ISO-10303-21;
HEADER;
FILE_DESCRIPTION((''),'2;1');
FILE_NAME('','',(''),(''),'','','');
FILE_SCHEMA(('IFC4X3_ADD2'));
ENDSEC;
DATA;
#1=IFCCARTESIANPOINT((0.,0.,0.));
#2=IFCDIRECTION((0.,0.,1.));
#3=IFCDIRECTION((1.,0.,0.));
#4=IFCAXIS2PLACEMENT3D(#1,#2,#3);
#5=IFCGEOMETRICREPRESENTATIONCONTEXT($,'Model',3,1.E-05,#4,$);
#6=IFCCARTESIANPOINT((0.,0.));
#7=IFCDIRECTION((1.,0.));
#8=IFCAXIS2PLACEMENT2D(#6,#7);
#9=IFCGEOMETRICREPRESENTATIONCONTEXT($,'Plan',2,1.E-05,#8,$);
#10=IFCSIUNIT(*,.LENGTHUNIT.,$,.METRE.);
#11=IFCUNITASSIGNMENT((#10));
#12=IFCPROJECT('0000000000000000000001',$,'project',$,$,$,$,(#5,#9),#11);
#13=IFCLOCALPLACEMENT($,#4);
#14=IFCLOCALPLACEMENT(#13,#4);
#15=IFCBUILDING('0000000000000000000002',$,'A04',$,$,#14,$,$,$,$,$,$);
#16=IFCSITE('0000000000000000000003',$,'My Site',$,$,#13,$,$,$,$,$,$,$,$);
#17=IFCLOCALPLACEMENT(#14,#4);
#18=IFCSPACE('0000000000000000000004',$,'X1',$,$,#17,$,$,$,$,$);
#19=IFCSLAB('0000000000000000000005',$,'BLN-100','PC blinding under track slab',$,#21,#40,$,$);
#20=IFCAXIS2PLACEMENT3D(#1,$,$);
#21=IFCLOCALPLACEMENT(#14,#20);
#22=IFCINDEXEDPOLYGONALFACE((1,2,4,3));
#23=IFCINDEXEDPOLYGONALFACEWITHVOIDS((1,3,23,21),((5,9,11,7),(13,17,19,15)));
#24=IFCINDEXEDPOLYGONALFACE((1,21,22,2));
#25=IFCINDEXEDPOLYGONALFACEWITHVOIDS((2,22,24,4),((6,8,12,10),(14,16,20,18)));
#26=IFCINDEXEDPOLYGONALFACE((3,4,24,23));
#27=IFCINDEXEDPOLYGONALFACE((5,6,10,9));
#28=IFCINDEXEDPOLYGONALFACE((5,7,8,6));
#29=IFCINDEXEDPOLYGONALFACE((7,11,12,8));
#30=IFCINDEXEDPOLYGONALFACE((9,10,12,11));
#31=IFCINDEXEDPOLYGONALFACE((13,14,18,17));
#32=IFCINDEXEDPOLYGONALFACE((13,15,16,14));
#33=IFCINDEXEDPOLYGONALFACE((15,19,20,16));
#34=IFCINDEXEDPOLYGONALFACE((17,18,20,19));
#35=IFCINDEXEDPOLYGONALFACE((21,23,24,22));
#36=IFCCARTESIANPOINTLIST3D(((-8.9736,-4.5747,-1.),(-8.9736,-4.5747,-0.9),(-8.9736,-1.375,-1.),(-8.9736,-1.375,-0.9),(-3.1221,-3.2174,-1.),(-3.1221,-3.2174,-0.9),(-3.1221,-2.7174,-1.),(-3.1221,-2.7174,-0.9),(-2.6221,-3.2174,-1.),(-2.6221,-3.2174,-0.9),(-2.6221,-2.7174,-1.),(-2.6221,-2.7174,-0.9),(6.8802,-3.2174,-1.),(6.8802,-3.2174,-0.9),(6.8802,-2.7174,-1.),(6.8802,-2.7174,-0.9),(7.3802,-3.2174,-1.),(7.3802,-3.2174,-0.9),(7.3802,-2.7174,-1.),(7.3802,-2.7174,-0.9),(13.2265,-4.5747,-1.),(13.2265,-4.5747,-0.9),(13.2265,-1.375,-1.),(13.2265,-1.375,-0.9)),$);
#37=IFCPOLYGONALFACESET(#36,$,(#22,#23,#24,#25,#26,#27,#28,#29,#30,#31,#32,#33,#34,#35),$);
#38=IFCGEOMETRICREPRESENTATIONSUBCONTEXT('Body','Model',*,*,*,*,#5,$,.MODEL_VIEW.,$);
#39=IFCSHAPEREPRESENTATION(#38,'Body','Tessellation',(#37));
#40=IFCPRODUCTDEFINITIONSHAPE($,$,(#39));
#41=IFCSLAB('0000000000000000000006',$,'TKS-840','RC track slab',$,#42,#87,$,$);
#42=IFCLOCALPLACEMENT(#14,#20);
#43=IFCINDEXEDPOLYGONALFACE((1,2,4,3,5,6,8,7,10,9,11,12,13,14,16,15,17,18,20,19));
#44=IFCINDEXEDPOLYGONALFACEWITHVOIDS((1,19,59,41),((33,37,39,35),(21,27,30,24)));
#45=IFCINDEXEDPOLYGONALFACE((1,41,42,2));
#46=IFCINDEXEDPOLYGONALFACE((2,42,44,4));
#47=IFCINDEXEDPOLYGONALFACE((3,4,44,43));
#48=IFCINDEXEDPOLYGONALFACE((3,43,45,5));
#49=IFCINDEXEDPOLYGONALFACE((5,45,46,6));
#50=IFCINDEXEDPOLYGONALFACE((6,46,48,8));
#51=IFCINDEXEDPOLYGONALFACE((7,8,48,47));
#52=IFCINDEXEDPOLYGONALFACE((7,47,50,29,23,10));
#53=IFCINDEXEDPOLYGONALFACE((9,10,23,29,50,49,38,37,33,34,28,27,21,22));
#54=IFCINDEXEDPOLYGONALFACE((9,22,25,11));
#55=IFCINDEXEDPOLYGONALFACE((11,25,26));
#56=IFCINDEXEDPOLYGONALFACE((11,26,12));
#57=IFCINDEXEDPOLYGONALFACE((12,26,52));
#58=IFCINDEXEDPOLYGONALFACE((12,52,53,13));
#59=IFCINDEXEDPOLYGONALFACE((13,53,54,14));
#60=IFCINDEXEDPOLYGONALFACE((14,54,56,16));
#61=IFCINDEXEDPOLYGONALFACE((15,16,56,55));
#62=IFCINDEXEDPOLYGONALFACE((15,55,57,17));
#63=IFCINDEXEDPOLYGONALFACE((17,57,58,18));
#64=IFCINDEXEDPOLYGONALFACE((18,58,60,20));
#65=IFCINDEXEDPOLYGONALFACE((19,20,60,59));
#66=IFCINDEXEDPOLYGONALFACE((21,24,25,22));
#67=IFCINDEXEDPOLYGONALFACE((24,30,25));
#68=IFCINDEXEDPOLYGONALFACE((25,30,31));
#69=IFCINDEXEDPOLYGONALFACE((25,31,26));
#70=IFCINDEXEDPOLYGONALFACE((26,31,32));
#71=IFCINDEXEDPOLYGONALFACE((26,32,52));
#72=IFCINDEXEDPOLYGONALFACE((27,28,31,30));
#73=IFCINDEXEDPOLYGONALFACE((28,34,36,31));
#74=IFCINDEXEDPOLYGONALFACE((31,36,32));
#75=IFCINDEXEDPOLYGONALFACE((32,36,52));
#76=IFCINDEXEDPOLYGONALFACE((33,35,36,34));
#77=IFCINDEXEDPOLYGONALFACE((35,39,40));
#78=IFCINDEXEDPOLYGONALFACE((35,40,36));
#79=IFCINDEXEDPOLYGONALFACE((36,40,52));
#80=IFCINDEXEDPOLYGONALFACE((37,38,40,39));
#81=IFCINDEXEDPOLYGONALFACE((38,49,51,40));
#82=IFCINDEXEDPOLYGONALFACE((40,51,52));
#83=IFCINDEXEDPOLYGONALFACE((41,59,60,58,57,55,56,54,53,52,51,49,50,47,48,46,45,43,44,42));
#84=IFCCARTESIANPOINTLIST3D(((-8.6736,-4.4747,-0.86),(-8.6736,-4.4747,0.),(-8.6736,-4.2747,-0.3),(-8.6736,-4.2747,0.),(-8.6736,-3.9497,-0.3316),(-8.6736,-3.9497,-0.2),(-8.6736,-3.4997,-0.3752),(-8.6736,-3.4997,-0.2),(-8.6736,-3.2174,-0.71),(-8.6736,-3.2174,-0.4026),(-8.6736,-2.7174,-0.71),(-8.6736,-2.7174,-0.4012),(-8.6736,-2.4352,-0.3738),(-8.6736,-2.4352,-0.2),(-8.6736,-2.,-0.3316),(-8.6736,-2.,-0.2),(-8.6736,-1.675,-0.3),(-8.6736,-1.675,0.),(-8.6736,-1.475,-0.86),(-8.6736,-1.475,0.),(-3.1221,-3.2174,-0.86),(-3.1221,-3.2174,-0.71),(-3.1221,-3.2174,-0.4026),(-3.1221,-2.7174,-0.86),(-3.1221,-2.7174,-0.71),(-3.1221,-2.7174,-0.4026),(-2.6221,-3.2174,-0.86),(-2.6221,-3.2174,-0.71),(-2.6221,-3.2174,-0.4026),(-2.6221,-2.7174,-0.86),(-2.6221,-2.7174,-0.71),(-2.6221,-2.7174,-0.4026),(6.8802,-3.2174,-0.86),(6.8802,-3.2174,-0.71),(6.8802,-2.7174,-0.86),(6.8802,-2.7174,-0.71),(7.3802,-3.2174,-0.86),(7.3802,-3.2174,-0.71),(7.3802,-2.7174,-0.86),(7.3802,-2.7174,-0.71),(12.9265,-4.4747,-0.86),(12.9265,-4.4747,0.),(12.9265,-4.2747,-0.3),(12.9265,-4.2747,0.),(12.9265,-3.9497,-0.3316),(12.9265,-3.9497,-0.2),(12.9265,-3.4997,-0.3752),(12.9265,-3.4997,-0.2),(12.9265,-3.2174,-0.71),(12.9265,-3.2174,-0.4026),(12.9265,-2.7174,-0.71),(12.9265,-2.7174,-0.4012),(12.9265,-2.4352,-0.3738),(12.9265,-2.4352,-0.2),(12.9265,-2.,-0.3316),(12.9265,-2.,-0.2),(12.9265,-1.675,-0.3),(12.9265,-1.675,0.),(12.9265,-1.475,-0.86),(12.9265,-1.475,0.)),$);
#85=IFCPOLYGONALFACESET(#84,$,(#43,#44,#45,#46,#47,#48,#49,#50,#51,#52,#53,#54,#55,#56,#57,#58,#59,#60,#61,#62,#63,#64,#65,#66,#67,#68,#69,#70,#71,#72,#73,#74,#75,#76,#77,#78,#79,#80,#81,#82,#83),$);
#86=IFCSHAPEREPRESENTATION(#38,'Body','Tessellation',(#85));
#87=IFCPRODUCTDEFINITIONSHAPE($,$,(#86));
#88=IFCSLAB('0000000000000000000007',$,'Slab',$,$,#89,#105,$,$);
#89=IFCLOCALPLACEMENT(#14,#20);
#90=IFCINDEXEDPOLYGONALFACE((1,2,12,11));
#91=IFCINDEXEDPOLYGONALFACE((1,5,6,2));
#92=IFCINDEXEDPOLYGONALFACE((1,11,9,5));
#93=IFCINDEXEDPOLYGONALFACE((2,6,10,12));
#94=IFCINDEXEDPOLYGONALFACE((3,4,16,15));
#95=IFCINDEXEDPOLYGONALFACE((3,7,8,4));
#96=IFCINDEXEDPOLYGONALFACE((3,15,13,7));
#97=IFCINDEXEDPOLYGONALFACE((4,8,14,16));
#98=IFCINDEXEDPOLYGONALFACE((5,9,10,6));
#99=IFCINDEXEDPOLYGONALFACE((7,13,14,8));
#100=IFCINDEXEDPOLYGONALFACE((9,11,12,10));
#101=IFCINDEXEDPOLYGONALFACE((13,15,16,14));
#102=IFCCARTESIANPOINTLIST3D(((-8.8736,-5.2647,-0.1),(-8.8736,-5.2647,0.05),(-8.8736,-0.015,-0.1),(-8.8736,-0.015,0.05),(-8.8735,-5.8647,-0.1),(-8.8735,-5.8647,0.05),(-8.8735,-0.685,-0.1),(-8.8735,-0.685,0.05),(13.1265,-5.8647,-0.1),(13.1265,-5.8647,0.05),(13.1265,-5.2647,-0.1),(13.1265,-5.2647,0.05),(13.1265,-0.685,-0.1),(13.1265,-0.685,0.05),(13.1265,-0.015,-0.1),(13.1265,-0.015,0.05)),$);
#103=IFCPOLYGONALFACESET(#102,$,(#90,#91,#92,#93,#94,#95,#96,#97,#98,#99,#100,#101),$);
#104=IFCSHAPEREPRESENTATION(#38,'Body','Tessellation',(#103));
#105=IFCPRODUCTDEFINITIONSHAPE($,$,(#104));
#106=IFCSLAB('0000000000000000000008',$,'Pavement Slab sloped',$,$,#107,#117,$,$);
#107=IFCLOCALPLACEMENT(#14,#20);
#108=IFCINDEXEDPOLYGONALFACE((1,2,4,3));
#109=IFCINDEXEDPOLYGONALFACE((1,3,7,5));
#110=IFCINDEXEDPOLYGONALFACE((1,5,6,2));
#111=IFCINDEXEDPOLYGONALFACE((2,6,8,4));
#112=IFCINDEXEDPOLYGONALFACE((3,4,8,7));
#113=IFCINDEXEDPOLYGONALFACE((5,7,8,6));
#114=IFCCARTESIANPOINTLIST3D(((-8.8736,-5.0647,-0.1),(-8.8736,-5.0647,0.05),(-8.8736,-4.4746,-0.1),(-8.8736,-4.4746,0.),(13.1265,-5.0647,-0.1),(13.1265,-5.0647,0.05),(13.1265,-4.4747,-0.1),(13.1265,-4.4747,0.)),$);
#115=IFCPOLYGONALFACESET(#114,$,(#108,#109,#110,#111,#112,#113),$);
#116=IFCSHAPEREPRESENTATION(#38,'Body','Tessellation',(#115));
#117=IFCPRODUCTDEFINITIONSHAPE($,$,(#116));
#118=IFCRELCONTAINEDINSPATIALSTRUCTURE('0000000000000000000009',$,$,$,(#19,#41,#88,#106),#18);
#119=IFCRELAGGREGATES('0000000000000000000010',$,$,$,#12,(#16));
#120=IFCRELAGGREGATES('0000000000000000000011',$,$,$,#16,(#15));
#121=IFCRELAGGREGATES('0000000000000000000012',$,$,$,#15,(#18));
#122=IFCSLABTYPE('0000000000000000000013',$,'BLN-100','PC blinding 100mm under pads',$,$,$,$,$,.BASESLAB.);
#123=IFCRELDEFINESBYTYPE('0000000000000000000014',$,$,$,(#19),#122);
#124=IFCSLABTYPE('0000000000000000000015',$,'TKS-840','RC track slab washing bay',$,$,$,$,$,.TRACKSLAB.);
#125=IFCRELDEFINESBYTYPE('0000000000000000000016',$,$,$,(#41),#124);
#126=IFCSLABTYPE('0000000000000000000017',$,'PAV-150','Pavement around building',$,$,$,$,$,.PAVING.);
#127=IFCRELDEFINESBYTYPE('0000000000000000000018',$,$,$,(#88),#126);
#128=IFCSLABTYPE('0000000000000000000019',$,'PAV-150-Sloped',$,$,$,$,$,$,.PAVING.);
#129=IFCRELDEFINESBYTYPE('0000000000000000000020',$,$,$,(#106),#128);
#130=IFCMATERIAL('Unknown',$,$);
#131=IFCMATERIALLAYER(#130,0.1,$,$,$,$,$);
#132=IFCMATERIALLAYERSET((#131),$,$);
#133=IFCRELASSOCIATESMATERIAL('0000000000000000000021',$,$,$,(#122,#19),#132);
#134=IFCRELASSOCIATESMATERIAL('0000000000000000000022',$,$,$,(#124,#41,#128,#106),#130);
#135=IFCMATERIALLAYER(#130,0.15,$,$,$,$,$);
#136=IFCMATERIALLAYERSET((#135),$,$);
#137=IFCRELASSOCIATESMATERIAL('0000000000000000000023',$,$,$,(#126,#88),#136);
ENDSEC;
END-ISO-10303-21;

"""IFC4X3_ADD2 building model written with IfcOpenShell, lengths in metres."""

from ifc_helpers import new_model, si_unit, frame, origin_with_axes, origin_2d_with_axis, place, context, subcontext, project, spatial, line, indexed_curve, outline, composite_profile, extrude, material, layer, layer_set, layer_usage, material_profile, profile_set, profile_usage, type_object, element, save


model = new_model("IFC4X3_ADD2")

# Units and contexts
model_context = context("Model", 3, precision=1e-05, world=origin_with_axes())
plan_context = context("Plan", 2, precision=1e-05, world=origin_2d_with_axis())
body_context = subcontext(model_context, "Body", "Model", "MODEL_VIEW")
ifc_project = project(units=[si_unit("LENGTHUNIT", "METRE")], contexts=[model_context, plan_context])

# Site, building, space
site_placement = place(None, origin_with_axes())
site = spatial("IfcSite", under=ifc_project, at=site_placement, Name="My Site")
building_placement = place(site_placement, origin_with_axes())
building = spatial("IfcBuilding", under=site, at=building_placement, Name="A04")
space_placement = place(building_placement, origin_with_axes())
space = spatial("IfcSpace", under=building, at=space_placement, Name="X1")

# Slab
ifc_material_1 = material(Name="Unknown")
ifc_layer_1 = layer(ifc_material_1, 0.1)
ifc_layer_set_1 = layer_set([ifc_layer_1])
ifc_layer_usage_1 = layer_usage(ifc_layer_set_1, "AXIS3", "POSITIVE", -0.1)
slab_type_1 = type_object("IfcSlabType", Name="BLN-100", Description="PC blinding 100mm under pads", PredefinedType="BASESLAB", material=ifc_layer_set_1)
slab_1_placement = place(space_placement, frame((-8.9736, -1.375, -0.9), z_axis=(0.0, 0.0, 1.0), x_axis=(1.0, 0.0, 0.0)))
element("IfcSlab", 1, at=slab_1_placement, inside=space, type_object=slab_type_1, material=ifc_layer_usage_1, Name="BLN-100", Description="PC blinding under track slab", context=body_context, shape_type="SweptSolid", body=[
    extrude(outline(indexed_curve([(0.0, 0.0), (22.2, 0.0), (22.2, -3.1997), (0.0, -3.1997), (0.0, 0.0)]), holes=[indexed_curve([(5.8514, -1.3424), (6.3514, -1.3424), (6.3514, -1.8424), (5.8514, -1.8424), (5.8514, -1.3424)]), indexed_curve([(15.8537, -1.3424), (16.3537, -1.3424), (16.3537, -1.8424), (15.8537, -1.8424), (15.8537, -1.3424)])]), frame((0.0, 0.0, -0.1), z_axis=(0.0, 0.0, 1.0), x_axis=(1.0, 0.0, 0.0)), (0.0, 0.0, 1.0), 0.1),
])

# Slab, openings
ifc_material_profile_1 = material_profile(ifc_material_1, outline(indexed_curve([(1.4998, 0.86), (1.4998, 0.0), (-1.4998, 0.0), (-1.4998, 0.86), (-1.2998, 0.86), (-1.2998, 0.56), (-0.9748, 0.5284), (-0.9748, 0.66), (-0.5248, 0.66), (-0.5248, 0.4848), (-0.2426, 0.4574), (-0.2426, 0.15), (0.2574, 0.15), (0.2574, 0.4588), (0.5396, 0.4862), (0.5396, 0.66), (0.9748, 0.66), (0.9748, 0.5284), (1.2998, 0.56), (1.2998, 0.86), (1.4998, 0.86)])))
ifc_profile_set_1 = profile_set([ifc_material_profile_1])
ifc_profile_usage_1 = profile_usage(ifc_profile_set_1, cardinal=5)
slab_type_2 = type_object("IfcSlabType", Name="TKS-840", Description="RC track slab washing bay", PredefinedType="TRACKSLAB", material=ifc_profile_set_1)
slab_2_placement = place(space_placement, frame((-8.6736, -2.9748, -0.86), z_axis=(1.0, 0.0, 0.0), x_axis=(0.0, 1.0, 0.0)))
slab_2 = element("IfcSlab", 2, at=slab_2_placement, inside=space, type_object=slab_type_2, material=ifc_profile_usage_1, Name="TKS-840", Description="RC track slab", context=body_context, shape_type="SweptSolid", body=[
    extrude(outline(indexed_curve([(1.4998, 0.86), (1.4998, 0.0), (-1.4998, 0.0), (-1.4998, 0.86), (-1.2998, 0.86), (-1.2998, 0.56), (-0.9748, 0.5284), (-0.9748, 0.66), (-0.5248, 0.66), (-0.5248, 0.4848), (-0.2426, 0.4574), (-0.2426, 0.15), (0.2574, 0.15), (0.2574, 0.4588), (0.5396, 0.4862), (0.5396, 0.66), (0.9748, 0.66), (0.9748, 0.5284), (1.2998, 0.56), (1.2998, 0.86), (1.4998, 0.86)])), origin_with_axes(), (0.0, 0.0, 1.0), 21.6),
])
opening_1_placement = place(slab_2_placement, frame((-0.2426, 0.0, 5.5514), z_axis=(0.0, 1.0, 0.0), x_axis=(0.0, 0.0, 1.0)))
element("IfcOpeningElement", 3, at=opening_1_placement, cuts=slab_2, PredefinedType="OPENING", context=body_context, shape_type="SweptSolid", body=[
    extrude(outline(indexed_curve([(0.0, 0.5), (0.5, 0.5), (0.5, 0.0), (0.0, 0.0), (0.0, 0.5)])), frame((0.0, 0.0, -0.3926), z_axis=(0.0, 0.0, 1.0), x_axis=(1.0, 0.0, 0.0)), (0.0, 0.0, 1.0), 0.85),
])
opening_2_placement = place(slab_2_placement, frame((-0.2426, -0.35, 15.5537), z_axis=(0.0, 1.0, 0.0), x_axis=(0.0, 0.0, 1.0)))
element("IfcOpeningElement", 4, at=opening_2_placement, cuts=slab_2, PredefinedType="OPENING", context=body_context, shape_type="SweptSolid", body=[
    extrude(outline(indexed_curve([(0.0, 0.0), (0.5, 0.0), (0.5, 0.5), (0.0, 0.5)], segments=[line(1, 2, 3, 4, 1)])), origin_with_axes(), (0.0, 0.0, 1.0), 0.5),
])

# Slabs
ifc_layer_2 = layer(ifc_material_1, 0.15)
ifc_layer_set_2 = layer_set([ifc_layer_2])
ifc_layer_usage_2 = layer_usage(ifc_layer_set_2, "AXIS3", "POSITIVE", -0.15)
slab_type_3 = type_object("IfcSlabType", Name="PAV-150", Description="Pavement around building", PredefinedType="PAVING", material=ifc_layer_set_2)
slab_3_placement = place(space_placement, frame((-8.8736, -5.2647, 0.05), z_axis=(0.0, 0.0, 1.0), x_axis=(1.0, 0.0, 0.0)))
element("IfcSlab", 5, at=slab_3_placement, inside=space, type_object=slab_type_3, material=ifc_layer_usage_2, Name="Slab", context=body_context, shape_type="SweptSolid", body=[
    extrude(composite_profile([outline(indexed_curve([(0.0, 4.5797), (22.0, 4.5797), (22.0, 5.2497), (0.0, 5.2497), (0.0, 4.5797)])), outline(indexed_curve([(0.0, -0.6), (22.0, -0.6), (22.0, 0.0), (0.0, 0.0), (0.0, -0.6)]))]), frame((0.0, 0.0, -0.15), z_axis=(0.0, 0.0, 1.0), x_axis=(1.0, 0.0, 0.0)), (0.0, 0.0, 1.0), 0.15),
])
ifc_material_profile_2 = material_profile(ifc_material_1, outline(indexed_curve([(0.59, 0.1), (0.59, 0.0), (0.0, 0.0), (0.0, 0.15), (0.59, 0.1)])))
ifc_profile_set_2 = profile_set([ifc_material_profile_2])
ifc_profile_usage_2 = profile_usage(ifc_profile_set_2, cardinal=5)
slab_type_4 = type_object("IfcSlabType", Name="PAV-150-Sloped", PredefinedType="PAVING", material=ifc_profile_set_2)
slab_4_placement = place(space_placement, frame((-8.8736, -5.0647, -0.1), z_axis=(1.0, -0.000002, -0.000001), x_axis=(0.000002, 1.0, 0.0)))
element("IfcSlab", 6, at=slab_4_placement, inside=space, type_object=slab_type_4, material=ifc_profile_usage_2, Name="Pavement Slab sloped", context=body_context, shape_type="SweptSolid", body=[
    extrude(outline(indexed_curve([(0.59, 0.1), (0.59, 0.0), (0.0, 0.0), (0.0, 0.15), (0.59, 0.1)])), origin_with_axes(), (0.0, 0.0, 1.0), 22.0),
])

save(model, "model.ifc")
